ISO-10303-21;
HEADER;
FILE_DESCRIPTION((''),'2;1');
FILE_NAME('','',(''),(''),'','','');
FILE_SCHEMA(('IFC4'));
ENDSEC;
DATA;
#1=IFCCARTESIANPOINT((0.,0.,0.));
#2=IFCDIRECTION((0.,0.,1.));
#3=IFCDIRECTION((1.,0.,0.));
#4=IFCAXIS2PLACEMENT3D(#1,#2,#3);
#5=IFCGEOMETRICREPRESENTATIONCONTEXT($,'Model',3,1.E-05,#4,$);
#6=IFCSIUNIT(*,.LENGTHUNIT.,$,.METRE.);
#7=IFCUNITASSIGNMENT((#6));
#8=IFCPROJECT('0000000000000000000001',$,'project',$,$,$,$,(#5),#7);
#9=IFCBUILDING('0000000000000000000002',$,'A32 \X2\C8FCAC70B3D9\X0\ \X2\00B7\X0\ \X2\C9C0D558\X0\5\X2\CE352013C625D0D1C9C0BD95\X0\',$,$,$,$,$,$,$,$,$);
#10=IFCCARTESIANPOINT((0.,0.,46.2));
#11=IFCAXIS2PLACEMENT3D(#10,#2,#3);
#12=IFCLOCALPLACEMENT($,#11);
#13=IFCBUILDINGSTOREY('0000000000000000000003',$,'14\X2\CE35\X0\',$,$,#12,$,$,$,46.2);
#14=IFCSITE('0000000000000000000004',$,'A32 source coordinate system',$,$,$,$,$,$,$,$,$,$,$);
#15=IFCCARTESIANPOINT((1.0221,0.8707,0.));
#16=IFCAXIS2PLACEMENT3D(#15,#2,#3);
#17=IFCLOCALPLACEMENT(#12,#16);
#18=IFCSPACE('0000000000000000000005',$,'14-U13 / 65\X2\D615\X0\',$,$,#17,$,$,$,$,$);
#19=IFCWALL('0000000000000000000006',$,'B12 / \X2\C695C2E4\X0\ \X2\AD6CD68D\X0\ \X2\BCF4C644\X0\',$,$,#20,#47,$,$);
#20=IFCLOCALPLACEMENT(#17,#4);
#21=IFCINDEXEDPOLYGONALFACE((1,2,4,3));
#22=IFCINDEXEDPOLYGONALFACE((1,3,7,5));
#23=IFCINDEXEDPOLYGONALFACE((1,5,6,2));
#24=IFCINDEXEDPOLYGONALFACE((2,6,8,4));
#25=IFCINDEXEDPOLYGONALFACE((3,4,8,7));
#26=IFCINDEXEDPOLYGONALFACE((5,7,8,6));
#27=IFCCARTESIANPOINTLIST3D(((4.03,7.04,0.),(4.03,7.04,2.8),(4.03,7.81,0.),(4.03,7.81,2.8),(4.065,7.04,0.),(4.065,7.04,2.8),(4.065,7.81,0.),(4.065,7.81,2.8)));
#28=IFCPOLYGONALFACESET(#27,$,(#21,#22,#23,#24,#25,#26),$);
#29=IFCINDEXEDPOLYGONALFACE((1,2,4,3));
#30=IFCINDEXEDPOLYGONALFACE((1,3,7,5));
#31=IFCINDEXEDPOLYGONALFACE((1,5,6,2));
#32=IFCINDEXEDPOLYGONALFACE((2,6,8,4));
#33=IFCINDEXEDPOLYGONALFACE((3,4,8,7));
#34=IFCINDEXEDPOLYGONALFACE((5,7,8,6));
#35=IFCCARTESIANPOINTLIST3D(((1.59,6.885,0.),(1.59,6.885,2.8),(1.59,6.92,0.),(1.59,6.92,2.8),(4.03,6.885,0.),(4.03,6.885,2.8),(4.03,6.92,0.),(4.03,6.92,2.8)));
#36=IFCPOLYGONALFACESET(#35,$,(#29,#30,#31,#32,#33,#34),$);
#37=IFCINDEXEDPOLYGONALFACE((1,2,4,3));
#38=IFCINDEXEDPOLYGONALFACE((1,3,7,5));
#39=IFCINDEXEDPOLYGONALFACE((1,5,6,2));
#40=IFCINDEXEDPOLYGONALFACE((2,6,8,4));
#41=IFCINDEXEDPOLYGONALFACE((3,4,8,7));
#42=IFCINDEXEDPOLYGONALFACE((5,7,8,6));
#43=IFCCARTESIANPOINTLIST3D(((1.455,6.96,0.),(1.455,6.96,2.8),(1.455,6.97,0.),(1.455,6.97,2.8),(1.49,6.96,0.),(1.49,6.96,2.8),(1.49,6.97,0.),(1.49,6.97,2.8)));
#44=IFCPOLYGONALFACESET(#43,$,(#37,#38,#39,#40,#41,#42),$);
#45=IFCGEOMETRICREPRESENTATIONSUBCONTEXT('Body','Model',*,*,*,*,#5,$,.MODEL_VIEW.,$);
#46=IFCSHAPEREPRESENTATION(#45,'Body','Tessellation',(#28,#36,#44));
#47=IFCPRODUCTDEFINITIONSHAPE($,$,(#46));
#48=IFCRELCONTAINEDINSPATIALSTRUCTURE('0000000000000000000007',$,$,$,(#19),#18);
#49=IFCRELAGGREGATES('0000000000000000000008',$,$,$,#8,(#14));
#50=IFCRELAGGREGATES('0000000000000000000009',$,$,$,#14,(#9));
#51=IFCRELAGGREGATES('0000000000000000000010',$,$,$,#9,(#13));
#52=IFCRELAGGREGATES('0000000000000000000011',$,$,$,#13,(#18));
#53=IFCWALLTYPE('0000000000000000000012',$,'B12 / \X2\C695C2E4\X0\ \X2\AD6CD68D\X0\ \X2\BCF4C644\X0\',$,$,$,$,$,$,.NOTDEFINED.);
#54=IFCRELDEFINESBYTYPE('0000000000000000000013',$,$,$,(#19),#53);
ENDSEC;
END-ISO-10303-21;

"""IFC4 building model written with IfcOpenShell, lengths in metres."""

from ifc_helpers import new_model, si_unit, frame, origin, origin_with_axes, place, context, subcontext, project, spatial, polyline, outline, extrude, source, transform, mapped, type_object, type_shapes, element, save


model = new_model("IFC4")

# Units and contexts
model_context = context("Model", 3, precision=1e-05, world=origin_with_axes())
body_context = subcontext(model_context, "Body", "Model", "MODEL_VIEW")
ifc_project = project(units=[si_unit("LENGTHUNIT", "METRE")], contexts=[model_context])

# Site, building, storey, space
storey_placement = place(None, frame((0.0, 0.0, 46.2), z_axis=(0.0, 0.0, 1.0), x_axis=(1.0, 0.0, 0.0)))
space_placement = place(storey_placement, frame((1.0221, 0.8707, 0.0), z_axis=(0.0, 0.0, 1.0), x_axis=(1.0, 0.0, 0.0)))
site = spatial("IfcSite", under=ifc_project, Name="A32 source coordinate system")
building = spatial("IfcBuilding", under=site, Name="A32 주거동 · 지하5층–옥탑지붕")
storey = spatial("IfcBuildingStorey", under=building, at=storey_placement, Name="14층", Elevation=46.2)
space = spatial("IfcSpace", under=storey, at=space_placement, Name="14-U13 / 65형")

# Wall
wall_type_1 = type_object("IfcWallType", Name="B12 / 욕실 구획 보완", PredefinedType="NOTDEFINED")
shared_shape_1 = source(origin(), body_context, "Body", "SweptSolid", [
    extrude(outline(polyline([(4.065, 7.04), (4.03, 7.04), (4.03, 7.81), (4.065, 7.81), (4.065, 7.04)])), origin(), (0.0, 0.0, 1.0), 2.8),
    extrude(outline(polyline([(1.59, 6.92), (4.03, 6.92), (4.03, 6.885), (1.59, 6.885), (1.59, 6.92)])), origin(), (0.0, 0.0, 1.0), 2.8),
    extrude(outline(polyline([(1.455, 6.97), (1.49, 6.97), (1.49, 6.96), (1.455, 6.96), (1.455, 6.97)])), origin(), (0.0, 0.0, 1.0), 2.8),
])
type_shapes(wall_type_1, [shared_shape_1])
wall_1_placement = place(space_placement, origin_with_axes())
element("IfcWall", 1, at=wall_1_placement, inside=space, type_object=wall_type_1, Name="B12 / 욕실 구획 보완", context=body_context, shape_type="MappedRepresentation", body=[
    mapped(shared_shape_1, transform((0.0, 0.0, 0.0), scale=1.0)),
])

save(model, "model.ifc")
